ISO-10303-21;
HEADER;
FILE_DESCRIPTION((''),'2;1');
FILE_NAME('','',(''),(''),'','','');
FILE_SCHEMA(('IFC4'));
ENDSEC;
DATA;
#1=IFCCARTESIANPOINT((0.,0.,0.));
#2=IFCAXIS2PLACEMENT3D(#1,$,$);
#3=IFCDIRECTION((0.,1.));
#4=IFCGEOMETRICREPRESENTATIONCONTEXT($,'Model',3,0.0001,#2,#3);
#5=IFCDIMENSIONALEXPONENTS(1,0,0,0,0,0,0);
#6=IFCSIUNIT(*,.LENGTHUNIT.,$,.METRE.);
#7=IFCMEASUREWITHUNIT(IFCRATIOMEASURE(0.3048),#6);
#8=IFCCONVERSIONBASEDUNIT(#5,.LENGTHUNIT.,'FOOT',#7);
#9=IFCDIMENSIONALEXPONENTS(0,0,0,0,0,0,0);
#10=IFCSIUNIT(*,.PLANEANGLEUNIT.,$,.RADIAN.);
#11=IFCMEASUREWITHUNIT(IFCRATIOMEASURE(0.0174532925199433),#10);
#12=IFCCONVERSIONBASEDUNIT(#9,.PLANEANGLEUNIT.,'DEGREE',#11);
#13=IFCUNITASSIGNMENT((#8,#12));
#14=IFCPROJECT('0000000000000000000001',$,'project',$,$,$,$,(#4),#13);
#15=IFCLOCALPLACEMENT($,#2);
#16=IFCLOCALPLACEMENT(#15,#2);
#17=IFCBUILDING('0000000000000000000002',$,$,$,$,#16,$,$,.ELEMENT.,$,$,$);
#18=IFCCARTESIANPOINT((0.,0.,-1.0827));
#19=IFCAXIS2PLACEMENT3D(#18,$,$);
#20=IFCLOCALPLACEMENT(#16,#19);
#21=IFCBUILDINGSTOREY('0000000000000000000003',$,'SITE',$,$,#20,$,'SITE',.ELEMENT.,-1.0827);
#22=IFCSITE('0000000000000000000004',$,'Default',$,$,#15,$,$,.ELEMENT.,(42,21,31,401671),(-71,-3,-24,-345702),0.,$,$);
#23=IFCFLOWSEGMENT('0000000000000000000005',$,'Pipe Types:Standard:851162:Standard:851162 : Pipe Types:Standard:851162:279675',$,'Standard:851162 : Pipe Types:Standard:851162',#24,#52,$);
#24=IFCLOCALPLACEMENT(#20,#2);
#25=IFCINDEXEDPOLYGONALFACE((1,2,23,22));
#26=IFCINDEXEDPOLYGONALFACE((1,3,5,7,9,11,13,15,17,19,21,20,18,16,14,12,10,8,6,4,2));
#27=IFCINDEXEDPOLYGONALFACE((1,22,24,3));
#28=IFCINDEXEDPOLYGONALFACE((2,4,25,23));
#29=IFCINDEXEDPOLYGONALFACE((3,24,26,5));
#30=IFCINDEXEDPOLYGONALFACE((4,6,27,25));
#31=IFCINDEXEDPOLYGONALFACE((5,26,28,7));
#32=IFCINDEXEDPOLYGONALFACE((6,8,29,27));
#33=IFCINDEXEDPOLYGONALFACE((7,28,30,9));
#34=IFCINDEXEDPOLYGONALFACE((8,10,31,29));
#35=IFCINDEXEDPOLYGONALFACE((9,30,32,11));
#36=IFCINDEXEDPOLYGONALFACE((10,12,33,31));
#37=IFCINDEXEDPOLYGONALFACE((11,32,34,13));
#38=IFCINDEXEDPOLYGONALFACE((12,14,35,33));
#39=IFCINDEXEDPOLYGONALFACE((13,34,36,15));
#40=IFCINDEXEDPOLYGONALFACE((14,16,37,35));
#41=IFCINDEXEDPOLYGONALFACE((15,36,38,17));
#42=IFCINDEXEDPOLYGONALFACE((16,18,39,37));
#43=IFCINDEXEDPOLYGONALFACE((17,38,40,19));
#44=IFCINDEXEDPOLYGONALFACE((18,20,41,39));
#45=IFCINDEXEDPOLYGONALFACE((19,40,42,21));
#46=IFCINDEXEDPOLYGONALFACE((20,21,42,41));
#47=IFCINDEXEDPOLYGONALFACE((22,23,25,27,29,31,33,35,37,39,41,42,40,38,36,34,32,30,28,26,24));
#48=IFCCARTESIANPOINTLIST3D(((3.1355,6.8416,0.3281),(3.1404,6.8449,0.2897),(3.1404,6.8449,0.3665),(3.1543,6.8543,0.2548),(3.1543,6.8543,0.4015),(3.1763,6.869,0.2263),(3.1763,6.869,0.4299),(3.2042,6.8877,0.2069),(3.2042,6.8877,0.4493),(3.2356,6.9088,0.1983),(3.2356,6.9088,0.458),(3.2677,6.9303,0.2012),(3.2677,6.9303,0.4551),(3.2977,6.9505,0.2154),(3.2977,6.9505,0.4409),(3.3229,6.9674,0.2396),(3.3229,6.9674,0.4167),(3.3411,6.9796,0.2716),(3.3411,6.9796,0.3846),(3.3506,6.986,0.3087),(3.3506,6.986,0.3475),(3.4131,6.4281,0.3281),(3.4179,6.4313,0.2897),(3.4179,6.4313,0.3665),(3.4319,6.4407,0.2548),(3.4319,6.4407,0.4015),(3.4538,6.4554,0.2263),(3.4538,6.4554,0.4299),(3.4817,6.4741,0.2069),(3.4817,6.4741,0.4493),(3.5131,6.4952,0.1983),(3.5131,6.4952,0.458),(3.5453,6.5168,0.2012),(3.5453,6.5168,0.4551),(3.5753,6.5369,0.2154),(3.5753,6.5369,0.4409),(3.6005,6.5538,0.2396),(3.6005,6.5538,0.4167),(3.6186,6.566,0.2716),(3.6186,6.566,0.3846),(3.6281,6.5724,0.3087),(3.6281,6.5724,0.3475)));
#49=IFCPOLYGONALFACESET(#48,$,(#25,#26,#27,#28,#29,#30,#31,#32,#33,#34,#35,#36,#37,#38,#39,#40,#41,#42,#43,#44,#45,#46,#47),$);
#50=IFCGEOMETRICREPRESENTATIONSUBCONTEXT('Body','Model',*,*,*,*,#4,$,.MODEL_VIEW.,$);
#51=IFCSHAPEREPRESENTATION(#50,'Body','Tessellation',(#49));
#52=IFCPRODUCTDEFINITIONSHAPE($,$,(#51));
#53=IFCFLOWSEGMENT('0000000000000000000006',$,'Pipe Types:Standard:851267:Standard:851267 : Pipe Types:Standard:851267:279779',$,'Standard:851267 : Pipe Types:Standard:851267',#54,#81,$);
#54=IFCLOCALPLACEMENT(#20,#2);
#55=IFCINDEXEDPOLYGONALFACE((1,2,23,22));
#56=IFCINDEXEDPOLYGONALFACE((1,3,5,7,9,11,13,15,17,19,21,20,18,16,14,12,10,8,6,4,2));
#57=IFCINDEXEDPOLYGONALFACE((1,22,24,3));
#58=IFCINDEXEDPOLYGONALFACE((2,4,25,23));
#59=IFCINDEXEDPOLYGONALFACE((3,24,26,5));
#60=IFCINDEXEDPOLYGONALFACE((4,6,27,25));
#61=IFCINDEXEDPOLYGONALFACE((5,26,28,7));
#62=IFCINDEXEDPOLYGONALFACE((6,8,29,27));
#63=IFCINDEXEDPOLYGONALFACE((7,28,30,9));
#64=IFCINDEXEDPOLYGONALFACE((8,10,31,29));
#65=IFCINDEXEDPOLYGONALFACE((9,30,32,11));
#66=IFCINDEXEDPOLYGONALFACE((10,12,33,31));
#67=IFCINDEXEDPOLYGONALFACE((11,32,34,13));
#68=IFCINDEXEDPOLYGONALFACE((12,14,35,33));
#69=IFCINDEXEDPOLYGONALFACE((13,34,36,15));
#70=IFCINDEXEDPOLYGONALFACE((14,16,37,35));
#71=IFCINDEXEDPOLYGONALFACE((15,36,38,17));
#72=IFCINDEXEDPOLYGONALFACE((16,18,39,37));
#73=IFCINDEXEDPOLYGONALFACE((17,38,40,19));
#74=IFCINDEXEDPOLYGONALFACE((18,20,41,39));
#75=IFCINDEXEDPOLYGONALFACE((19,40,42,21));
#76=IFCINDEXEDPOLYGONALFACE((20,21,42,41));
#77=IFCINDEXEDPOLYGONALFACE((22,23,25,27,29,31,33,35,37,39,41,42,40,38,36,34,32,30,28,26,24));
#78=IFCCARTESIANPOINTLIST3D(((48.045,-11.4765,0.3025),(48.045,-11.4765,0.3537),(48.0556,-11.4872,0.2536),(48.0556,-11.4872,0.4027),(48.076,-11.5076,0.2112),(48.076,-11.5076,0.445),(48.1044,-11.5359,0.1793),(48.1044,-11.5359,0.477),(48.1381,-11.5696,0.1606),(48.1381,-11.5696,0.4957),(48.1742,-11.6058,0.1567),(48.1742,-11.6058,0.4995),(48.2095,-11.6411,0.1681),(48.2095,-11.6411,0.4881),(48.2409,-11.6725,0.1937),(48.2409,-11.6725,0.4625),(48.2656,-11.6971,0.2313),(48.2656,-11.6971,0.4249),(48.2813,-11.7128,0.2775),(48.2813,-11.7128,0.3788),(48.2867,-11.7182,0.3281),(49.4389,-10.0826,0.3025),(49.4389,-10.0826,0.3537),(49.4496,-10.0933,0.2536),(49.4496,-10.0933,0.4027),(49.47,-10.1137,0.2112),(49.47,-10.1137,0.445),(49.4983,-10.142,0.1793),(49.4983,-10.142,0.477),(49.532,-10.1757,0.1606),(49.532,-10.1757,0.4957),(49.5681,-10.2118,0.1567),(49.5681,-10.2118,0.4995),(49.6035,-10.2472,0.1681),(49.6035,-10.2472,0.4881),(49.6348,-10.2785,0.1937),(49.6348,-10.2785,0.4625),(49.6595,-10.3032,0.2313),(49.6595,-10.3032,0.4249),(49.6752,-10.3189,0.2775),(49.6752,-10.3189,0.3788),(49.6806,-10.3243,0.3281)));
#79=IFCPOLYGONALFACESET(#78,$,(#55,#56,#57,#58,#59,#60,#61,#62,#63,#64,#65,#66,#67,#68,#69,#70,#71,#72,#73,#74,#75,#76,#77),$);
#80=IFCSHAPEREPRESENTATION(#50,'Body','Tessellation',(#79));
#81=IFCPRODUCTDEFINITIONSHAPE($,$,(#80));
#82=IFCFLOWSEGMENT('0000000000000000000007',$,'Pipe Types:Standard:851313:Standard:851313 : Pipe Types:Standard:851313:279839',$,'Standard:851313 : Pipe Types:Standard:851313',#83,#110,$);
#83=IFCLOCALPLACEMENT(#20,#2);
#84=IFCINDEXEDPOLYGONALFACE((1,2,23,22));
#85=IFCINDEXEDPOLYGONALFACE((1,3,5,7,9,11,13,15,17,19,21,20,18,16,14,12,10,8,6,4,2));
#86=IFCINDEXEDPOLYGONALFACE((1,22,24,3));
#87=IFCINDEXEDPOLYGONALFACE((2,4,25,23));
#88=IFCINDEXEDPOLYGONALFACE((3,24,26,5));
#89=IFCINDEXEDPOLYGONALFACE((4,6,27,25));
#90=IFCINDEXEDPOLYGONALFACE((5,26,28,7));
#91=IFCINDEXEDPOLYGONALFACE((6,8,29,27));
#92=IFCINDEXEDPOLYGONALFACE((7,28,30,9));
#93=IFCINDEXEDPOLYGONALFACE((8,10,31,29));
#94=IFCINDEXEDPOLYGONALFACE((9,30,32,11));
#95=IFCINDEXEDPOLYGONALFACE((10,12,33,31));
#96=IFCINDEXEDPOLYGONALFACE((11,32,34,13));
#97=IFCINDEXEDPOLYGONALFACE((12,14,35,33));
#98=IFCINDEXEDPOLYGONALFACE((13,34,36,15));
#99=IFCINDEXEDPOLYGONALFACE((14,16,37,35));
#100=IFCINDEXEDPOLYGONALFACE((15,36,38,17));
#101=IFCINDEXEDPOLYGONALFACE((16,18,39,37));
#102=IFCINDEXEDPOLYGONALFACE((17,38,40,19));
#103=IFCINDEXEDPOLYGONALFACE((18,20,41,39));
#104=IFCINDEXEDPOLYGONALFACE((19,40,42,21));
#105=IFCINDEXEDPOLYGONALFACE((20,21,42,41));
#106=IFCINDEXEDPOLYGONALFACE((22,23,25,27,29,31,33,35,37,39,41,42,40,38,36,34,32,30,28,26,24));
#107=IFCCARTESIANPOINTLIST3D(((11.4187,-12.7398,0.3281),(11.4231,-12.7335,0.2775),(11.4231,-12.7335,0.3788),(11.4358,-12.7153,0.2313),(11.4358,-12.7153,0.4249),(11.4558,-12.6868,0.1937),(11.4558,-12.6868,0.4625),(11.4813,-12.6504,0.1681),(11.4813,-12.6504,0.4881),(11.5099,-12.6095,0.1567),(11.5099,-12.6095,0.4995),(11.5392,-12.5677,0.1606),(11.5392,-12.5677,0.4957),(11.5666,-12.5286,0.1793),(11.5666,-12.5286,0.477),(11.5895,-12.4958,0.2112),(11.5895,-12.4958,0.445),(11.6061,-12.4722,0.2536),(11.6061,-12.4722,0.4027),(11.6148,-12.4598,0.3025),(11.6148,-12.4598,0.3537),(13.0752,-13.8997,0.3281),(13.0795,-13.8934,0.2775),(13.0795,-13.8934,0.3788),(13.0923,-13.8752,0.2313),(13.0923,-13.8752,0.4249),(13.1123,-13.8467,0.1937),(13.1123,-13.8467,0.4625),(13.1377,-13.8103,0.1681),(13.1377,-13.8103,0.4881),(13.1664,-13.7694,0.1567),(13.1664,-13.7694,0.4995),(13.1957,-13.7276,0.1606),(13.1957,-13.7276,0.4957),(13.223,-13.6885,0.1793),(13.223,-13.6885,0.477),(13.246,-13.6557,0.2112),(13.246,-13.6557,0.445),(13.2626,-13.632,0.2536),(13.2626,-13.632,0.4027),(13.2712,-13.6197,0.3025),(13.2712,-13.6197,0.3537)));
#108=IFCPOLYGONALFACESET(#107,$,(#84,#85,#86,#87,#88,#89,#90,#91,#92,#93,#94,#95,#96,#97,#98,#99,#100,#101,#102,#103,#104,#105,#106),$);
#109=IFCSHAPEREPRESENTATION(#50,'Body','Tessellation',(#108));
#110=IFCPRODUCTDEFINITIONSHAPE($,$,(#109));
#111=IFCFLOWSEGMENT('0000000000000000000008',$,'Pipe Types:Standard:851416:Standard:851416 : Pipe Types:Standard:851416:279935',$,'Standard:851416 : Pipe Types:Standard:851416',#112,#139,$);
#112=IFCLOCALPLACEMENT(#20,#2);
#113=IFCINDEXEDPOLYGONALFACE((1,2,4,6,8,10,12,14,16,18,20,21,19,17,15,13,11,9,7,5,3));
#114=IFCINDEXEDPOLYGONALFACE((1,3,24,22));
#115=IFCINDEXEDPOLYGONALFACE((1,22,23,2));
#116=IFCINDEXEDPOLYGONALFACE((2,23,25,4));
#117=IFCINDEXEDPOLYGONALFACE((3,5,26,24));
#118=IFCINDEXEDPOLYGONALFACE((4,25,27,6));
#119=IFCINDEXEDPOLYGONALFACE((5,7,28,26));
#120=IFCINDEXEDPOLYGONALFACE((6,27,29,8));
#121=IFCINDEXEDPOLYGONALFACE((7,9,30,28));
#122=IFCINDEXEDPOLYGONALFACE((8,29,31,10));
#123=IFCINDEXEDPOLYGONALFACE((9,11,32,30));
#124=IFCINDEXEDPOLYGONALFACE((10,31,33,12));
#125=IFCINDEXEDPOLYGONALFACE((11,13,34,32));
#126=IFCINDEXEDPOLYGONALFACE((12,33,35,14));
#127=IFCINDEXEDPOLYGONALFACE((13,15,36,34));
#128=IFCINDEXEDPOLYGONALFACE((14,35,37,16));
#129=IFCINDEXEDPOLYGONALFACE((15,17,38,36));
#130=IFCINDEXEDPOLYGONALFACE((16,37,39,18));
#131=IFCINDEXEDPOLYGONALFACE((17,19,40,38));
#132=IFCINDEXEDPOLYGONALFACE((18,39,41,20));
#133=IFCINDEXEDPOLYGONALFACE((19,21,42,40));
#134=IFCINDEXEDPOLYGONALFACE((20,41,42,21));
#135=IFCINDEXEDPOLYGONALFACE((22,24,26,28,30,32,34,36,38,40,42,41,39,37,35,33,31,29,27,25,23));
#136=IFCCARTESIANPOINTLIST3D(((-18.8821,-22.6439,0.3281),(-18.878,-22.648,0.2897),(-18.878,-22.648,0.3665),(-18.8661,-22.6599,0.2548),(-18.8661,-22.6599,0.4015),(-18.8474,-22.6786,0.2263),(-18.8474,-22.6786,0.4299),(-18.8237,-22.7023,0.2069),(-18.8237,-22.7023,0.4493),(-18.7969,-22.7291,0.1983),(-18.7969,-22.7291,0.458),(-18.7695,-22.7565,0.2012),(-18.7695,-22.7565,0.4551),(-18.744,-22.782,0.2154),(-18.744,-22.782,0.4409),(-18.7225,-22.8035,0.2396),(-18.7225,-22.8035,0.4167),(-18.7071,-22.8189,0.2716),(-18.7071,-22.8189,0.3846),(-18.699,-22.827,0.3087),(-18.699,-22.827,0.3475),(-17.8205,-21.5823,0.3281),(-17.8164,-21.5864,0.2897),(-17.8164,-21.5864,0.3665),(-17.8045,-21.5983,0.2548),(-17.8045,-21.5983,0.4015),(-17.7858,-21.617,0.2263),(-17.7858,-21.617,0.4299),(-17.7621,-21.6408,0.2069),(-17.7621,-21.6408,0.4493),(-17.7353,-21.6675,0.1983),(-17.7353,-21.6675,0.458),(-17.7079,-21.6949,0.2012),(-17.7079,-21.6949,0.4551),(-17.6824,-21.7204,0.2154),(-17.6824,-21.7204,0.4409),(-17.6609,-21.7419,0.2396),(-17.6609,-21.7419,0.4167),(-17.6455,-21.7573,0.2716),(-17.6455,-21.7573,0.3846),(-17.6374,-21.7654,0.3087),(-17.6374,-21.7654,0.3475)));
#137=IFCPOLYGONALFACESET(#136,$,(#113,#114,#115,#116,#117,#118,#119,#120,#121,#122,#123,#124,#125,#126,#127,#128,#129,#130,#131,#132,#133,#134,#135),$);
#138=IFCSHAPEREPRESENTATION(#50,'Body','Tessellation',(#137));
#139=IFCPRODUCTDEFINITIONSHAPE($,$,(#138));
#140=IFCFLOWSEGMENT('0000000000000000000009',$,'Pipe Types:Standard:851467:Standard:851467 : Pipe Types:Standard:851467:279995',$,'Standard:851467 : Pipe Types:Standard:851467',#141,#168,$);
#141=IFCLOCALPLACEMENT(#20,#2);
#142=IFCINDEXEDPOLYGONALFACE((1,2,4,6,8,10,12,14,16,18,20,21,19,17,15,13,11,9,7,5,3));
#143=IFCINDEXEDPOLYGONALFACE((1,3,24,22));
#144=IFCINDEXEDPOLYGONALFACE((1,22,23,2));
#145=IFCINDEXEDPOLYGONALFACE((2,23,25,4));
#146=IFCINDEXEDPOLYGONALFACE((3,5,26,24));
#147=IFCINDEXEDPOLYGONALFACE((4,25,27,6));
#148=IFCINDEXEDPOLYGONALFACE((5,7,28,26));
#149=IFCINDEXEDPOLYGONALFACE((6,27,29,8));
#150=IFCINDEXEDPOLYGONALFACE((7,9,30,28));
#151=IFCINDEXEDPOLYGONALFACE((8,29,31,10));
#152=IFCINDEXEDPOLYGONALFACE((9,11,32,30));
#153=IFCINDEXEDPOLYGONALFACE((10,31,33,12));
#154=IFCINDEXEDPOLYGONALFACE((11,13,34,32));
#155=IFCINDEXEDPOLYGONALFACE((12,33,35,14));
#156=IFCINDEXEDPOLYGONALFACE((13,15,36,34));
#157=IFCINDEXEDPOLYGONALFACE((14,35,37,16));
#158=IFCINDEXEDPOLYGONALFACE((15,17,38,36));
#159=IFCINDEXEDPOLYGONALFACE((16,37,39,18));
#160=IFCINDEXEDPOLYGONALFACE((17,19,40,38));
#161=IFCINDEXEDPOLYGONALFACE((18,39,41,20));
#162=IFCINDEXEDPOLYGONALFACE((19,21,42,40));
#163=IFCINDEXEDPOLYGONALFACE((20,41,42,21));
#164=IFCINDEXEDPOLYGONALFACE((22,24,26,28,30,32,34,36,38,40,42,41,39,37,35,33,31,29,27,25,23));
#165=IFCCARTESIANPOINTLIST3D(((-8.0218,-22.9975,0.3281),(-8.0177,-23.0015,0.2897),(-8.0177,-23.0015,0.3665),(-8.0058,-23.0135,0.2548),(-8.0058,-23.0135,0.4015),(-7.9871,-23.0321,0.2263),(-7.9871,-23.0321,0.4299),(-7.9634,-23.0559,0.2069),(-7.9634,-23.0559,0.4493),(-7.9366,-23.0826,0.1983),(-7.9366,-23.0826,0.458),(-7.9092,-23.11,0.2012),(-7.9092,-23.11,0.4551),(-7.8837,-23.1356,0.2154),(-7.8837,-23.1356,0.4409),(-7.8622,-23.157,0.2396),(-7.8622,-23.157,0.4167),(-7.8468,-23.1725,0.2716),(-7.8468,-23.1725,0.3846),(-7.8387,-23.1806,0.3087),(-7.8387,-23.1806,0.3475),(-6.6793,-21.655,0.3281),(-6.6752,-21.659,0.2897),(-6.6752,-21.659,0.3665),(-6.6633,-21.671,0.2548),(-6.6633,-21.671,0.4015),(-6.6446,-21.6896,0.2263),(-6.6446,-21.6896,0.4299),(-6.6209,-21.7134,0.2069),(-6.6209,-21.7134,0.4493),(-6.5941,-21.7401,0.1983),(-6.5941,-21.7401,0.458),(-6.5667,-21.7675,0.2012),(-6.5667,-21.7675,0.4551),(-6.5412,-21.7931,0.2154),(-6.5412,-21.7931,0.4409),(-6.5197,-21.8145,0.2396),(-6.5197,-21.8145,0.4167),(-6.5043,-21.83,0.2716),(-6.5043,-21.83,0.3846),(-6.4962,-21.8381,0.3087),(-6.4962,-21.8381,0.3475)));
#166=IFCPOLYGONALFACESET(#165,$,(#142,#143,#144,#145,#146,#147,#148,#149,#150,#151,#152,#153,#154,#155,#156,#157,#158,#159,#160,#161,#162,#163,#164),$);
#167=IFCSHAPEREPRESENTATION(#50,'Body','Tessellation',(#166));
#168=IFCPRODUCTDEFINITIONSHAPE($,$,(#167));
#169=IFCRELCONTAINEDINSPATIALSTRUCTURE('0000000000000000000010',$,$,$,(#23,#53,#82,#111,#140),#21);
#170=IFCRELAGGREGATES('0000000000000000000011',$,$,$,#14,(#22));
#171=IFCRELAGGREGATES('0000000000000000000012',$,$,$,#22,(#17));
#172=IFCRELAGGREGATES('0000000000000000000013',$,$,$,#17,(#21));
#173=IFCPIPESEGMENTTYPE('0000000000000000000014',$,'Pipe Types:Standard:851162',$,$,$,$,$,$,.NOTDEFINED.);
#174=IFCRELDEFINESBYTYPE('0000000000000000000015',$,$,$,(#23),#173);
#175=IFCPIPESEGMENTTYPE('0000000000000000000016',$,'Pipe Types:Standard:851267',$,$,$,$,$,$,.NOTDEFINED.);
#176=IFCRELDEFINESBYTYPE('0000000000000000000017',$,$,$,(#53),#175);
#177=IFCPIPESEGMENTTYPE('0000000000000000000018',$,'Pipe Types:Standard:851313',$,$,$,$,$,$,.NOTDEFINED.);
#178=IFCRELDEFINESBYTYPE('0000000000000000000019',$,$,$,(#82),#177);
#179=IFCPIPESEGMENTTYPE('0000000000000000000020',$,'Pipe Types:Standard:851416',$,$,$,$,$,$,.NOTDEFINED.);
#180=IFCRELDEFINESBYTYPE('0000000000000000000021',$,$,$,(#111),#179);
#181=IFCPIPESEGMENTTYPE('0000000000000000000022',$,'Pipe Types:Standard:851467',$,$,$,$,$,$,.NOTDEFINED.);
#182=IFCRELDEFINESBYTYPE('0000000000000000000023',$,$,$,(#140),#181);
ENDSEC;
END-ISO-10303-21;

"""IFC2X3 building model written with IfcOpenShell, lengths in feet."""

from ifc_helpers import new_model, entity, si_unit, converted_unit, direction, frame, frame_2d, origin, place, context, subcontext, project, spatial, circle, extrude, source, transform, mapped, type_object, type_shapes, element, save


model = new_model("IFC2X3")

# Units and contexts
model_context = context("Model", 3, precision=0.0001, world=origin(), true_north=direction((0.0, 1.0)))
body_context = subcontext(model_context, "Body", "Model", "MODEL_VIEW")
ifc_project = project(units=[converted_unit("LENGTHUNIT", "FOOT", entity("IfcRatioMeasure", 0.3048), si_unit("LENGTHUNIT", "METRE"), dimensions=[1, 0, 0, 0, 0, 0, 0]), converted_unit("PLANEANGLEUNIT", "DEGREE", entity("IfcRatioMeasure", 0.0174532925199433), si_unit("PLANEANGLEUNIT", "RADIAN"), dimensions=[0, 0, 0, 0, 0, 0, 0])], contexts=[model_context])

# Site, building, storey
site_placement = place(None, origin())
site = spatial("IfcSite", under=ifc_project, at=site_placement, Name="Default", CompositionType="ELEMENT", RefLatitude=(42, 21, 31, 401671), RefLongitude=(-71, -3, -24, -345702), RefElevation=0.0)
building_placement = place(site_placement, origin())
building = spatial("IfcBuilding", under=site, at=building_placement, CompositionType="ELEMENT")
storey_placement = place(building_placement, frame((0.0, 0.0, -1.0827)))
storey = spatial("IfcBuildingStorey", under=building, at=storey_placement, Name="SITE", LongName="SITE", CompositionType="ELEMENT", Elevation=-1.0827)

# Flow segments
pipe_segment_type_1 = type_object("IfcPipeSegmentType", Name="Pipe Types:Standard:851162", PredefinedType="NOTDEFINED")
shared_shape_1 = source(origin(), body_context, "Body", "SweptSolid", [
    extrude(circle(Radius=0.1302, at=frame_2d((0.0, 0.0), x_axis=(1.0, 0.0))), frame((3.5212, 6.5006, -0.7546), z_axis=(-0.557235, 0.830355, 0.0), x_axis=(-0.830355, -0.557235, 0.0)), (0.0, 0.0, 1.0), 0.4981),
])
type_shapes(pipe_segment_type_1, [shared_shape_1])
flow_segment_1_placement = place(storey_placement, frame((0.0, 0.0, 1.0827)))
element("IfcFlowSegment", 1, at=flow_segment_1_placement, inside=storey, type_object=pipe_segment_type_1, Name="Pipe Types:Standard:851162:Standard:851162 : Pipe Types:Standard:851162:279675", ObjectType="Standard:851162 : Pipe Types:Standard:851162", context=body_context, shape_type="MappedRepresentation", body=[
    mapped(shared_shape_1, transform((0.0, 0.0, 0.0), scale=1.0)),
])
pipe_segment_type_2 = type_object("IfcPipeSegmentType", Name="Pipe Types:Standard:851267", PredefinedType="NOTDEFINED")
shared_shape_2 = source(origin(), body_context, "Body", "SweptSolid", [
    extrude(circle(Radius=0.1719, at=frame_2d((0.0, 0.0), x_axis=(1.0, 0.0))), frame((48.1651, -11.5967, -0.7546), z_axis=(0.707107, 0.707107, 0.0), x_axis=(0.707107, -0.707107, 0.0)), (0.0, 0.0, 1.0), 1.9713),
])
type_shapes(pipe_segment_type_2, [shared_shape_2])
flow_segment_2_placement = place(storey_placement, frame((0.0, 0.0, 1.0827)))
element("IfcFlowSegment", 2, at=flow_segment_2_placement, inside=storey, type_object=pipe_segment_type_2, Name="Pipe Types:Standard:851267:Standard:851267 : Pipe Types:Standard:851267:279779", ObjectType="Standard:851267 : Pipe Types:Standard:851267", context=body_context, shape_type="MappedRepresentation", body=[
    mapped(shared_shape_2, transform((0.0, 0.0, 0.0), scale=1.0)),
])
pipe_segment_type_3 = type_object("IfcPipeSegmentType", Name="Pipe Types:Standard:851313", PredefinedType="NOTDEFINED")
shared_shape_3 = source(origin(), body_context, "Body", "SweptSolid", [
    extrude(circle(Radius=0.1719, at=frame_2d((0.0, 0.0), x_axis=(1.0, 0.0))), frame((13.1738, -13.7589, -0.7546), z_axis=(-0.819152, 0.573576, 0.0), x_axis=(-0.573576, -0.819152, 0.0)), (0.0, 0.0, 1.0), 2.0222),
])
type_shapes(pipe_segment_type_3, [shared_shape_3])
flow_segment_3_placement = place(storey_placement, frame((0.0, 0.0, 1.0827)))
element("IfcFlowSegment", 3, at=flow_segment_3_placement, inside=storey, type_object=pipe_segment_type_3, Name="Pipe Types:Standard:851313:Standard:851313 : Pipe Types:Standard:851313:279839", ObjectType="Standard:851313 : Pipe Types:Standard:851313", context=body_context, shape_type="MappedRepresentation", body=[
    mapped(shared_shape_3, transform((0.0, 0.0, 0.0), scale=1.0)),
])
pipe_segment_type_4 = type_object("IfcPipeSegmentType", Name="Pipe Types:Standard:851416", PredefinedType="NOTDEFINED")
shared_shape_4 = source(origin(), body_context, "Body", "SweptSolid", [
    extrude(circle(Radius=0.1302, at=frame_2d((0.0, 0.0), x_axis=(1.0, 0.0))), frame((-18.79, -22.736, -0.7546), z_axis=(0.707107, 0.707107, 0.0), x_axis=(-0.707107, 0.707107, 0.0)), (0.0, 0.0, 1.0), 1.5013),
])
type_shapes(pipe_segment_type_4, [shared_shape_4])
flow_segment_4_placement = place(storey_placement, frame((0.0, 0.0, 1.0827)))
element("IfcFlowSegment", 4, at=flow_segment_4_placement, inside=storey, type_object=pipe_segment_type_4, Name="Pipe Types:Standard:851416:Standard:851416 : Pipe Types:Standard:851416:279935", ObjectType="Standard:851416 : Pipe Types:Standard:851416", context=body_context, shape_type="MappedRepresentation", body=[
    mapped(shared_shape_4, transform((0.0, 0.0, 0.0), scale=1.0)),
])
pipe_segment_type_5 = type_object("IfcPipeSegmentType", Name="Pipe Types:Standard:851467", PredefinedType="NOTDEFINED")
shared_shape_5 = source(origin(), body_context, "Body", "SweptSolid", [
    extrude(circle(Radius=0.1302, at=frame_2d((0.0, 0.0), x_axis=(1.0, 0.0))), frame((-7.9297, -23.0895, -0.7546), z_axis=(0.707107, 0.707107, 0.0), x_axis=(-0.707107, 0.707107, 0.0)), (0.0, 0.0, 1.0), 1.8986),
])
type_shapes(pipe_segment_type_5, [shared_shape_5])
flow_segment_5_placement = place(storey_placement, frame((0.0, 0.0, 1.0827)))
element("IfcFlowSegment", 5, at=flow_segment_5_placement, inside=storey, type_object=pipe_segment_type_5, Name="Pipe Types:Standard:851467:Standard:851467 : Pipe Types:Standard:851467:279995", ObjectType="Standard:851467 : Pipe Types:Standard:851467", context=body_context, shape_type="MappedRepresentation", body=[
    mapped(shared_shape_5, transform((0.0, 0.0, 0.0), scale=1.0)),
])

save(model, "model.ifc")
